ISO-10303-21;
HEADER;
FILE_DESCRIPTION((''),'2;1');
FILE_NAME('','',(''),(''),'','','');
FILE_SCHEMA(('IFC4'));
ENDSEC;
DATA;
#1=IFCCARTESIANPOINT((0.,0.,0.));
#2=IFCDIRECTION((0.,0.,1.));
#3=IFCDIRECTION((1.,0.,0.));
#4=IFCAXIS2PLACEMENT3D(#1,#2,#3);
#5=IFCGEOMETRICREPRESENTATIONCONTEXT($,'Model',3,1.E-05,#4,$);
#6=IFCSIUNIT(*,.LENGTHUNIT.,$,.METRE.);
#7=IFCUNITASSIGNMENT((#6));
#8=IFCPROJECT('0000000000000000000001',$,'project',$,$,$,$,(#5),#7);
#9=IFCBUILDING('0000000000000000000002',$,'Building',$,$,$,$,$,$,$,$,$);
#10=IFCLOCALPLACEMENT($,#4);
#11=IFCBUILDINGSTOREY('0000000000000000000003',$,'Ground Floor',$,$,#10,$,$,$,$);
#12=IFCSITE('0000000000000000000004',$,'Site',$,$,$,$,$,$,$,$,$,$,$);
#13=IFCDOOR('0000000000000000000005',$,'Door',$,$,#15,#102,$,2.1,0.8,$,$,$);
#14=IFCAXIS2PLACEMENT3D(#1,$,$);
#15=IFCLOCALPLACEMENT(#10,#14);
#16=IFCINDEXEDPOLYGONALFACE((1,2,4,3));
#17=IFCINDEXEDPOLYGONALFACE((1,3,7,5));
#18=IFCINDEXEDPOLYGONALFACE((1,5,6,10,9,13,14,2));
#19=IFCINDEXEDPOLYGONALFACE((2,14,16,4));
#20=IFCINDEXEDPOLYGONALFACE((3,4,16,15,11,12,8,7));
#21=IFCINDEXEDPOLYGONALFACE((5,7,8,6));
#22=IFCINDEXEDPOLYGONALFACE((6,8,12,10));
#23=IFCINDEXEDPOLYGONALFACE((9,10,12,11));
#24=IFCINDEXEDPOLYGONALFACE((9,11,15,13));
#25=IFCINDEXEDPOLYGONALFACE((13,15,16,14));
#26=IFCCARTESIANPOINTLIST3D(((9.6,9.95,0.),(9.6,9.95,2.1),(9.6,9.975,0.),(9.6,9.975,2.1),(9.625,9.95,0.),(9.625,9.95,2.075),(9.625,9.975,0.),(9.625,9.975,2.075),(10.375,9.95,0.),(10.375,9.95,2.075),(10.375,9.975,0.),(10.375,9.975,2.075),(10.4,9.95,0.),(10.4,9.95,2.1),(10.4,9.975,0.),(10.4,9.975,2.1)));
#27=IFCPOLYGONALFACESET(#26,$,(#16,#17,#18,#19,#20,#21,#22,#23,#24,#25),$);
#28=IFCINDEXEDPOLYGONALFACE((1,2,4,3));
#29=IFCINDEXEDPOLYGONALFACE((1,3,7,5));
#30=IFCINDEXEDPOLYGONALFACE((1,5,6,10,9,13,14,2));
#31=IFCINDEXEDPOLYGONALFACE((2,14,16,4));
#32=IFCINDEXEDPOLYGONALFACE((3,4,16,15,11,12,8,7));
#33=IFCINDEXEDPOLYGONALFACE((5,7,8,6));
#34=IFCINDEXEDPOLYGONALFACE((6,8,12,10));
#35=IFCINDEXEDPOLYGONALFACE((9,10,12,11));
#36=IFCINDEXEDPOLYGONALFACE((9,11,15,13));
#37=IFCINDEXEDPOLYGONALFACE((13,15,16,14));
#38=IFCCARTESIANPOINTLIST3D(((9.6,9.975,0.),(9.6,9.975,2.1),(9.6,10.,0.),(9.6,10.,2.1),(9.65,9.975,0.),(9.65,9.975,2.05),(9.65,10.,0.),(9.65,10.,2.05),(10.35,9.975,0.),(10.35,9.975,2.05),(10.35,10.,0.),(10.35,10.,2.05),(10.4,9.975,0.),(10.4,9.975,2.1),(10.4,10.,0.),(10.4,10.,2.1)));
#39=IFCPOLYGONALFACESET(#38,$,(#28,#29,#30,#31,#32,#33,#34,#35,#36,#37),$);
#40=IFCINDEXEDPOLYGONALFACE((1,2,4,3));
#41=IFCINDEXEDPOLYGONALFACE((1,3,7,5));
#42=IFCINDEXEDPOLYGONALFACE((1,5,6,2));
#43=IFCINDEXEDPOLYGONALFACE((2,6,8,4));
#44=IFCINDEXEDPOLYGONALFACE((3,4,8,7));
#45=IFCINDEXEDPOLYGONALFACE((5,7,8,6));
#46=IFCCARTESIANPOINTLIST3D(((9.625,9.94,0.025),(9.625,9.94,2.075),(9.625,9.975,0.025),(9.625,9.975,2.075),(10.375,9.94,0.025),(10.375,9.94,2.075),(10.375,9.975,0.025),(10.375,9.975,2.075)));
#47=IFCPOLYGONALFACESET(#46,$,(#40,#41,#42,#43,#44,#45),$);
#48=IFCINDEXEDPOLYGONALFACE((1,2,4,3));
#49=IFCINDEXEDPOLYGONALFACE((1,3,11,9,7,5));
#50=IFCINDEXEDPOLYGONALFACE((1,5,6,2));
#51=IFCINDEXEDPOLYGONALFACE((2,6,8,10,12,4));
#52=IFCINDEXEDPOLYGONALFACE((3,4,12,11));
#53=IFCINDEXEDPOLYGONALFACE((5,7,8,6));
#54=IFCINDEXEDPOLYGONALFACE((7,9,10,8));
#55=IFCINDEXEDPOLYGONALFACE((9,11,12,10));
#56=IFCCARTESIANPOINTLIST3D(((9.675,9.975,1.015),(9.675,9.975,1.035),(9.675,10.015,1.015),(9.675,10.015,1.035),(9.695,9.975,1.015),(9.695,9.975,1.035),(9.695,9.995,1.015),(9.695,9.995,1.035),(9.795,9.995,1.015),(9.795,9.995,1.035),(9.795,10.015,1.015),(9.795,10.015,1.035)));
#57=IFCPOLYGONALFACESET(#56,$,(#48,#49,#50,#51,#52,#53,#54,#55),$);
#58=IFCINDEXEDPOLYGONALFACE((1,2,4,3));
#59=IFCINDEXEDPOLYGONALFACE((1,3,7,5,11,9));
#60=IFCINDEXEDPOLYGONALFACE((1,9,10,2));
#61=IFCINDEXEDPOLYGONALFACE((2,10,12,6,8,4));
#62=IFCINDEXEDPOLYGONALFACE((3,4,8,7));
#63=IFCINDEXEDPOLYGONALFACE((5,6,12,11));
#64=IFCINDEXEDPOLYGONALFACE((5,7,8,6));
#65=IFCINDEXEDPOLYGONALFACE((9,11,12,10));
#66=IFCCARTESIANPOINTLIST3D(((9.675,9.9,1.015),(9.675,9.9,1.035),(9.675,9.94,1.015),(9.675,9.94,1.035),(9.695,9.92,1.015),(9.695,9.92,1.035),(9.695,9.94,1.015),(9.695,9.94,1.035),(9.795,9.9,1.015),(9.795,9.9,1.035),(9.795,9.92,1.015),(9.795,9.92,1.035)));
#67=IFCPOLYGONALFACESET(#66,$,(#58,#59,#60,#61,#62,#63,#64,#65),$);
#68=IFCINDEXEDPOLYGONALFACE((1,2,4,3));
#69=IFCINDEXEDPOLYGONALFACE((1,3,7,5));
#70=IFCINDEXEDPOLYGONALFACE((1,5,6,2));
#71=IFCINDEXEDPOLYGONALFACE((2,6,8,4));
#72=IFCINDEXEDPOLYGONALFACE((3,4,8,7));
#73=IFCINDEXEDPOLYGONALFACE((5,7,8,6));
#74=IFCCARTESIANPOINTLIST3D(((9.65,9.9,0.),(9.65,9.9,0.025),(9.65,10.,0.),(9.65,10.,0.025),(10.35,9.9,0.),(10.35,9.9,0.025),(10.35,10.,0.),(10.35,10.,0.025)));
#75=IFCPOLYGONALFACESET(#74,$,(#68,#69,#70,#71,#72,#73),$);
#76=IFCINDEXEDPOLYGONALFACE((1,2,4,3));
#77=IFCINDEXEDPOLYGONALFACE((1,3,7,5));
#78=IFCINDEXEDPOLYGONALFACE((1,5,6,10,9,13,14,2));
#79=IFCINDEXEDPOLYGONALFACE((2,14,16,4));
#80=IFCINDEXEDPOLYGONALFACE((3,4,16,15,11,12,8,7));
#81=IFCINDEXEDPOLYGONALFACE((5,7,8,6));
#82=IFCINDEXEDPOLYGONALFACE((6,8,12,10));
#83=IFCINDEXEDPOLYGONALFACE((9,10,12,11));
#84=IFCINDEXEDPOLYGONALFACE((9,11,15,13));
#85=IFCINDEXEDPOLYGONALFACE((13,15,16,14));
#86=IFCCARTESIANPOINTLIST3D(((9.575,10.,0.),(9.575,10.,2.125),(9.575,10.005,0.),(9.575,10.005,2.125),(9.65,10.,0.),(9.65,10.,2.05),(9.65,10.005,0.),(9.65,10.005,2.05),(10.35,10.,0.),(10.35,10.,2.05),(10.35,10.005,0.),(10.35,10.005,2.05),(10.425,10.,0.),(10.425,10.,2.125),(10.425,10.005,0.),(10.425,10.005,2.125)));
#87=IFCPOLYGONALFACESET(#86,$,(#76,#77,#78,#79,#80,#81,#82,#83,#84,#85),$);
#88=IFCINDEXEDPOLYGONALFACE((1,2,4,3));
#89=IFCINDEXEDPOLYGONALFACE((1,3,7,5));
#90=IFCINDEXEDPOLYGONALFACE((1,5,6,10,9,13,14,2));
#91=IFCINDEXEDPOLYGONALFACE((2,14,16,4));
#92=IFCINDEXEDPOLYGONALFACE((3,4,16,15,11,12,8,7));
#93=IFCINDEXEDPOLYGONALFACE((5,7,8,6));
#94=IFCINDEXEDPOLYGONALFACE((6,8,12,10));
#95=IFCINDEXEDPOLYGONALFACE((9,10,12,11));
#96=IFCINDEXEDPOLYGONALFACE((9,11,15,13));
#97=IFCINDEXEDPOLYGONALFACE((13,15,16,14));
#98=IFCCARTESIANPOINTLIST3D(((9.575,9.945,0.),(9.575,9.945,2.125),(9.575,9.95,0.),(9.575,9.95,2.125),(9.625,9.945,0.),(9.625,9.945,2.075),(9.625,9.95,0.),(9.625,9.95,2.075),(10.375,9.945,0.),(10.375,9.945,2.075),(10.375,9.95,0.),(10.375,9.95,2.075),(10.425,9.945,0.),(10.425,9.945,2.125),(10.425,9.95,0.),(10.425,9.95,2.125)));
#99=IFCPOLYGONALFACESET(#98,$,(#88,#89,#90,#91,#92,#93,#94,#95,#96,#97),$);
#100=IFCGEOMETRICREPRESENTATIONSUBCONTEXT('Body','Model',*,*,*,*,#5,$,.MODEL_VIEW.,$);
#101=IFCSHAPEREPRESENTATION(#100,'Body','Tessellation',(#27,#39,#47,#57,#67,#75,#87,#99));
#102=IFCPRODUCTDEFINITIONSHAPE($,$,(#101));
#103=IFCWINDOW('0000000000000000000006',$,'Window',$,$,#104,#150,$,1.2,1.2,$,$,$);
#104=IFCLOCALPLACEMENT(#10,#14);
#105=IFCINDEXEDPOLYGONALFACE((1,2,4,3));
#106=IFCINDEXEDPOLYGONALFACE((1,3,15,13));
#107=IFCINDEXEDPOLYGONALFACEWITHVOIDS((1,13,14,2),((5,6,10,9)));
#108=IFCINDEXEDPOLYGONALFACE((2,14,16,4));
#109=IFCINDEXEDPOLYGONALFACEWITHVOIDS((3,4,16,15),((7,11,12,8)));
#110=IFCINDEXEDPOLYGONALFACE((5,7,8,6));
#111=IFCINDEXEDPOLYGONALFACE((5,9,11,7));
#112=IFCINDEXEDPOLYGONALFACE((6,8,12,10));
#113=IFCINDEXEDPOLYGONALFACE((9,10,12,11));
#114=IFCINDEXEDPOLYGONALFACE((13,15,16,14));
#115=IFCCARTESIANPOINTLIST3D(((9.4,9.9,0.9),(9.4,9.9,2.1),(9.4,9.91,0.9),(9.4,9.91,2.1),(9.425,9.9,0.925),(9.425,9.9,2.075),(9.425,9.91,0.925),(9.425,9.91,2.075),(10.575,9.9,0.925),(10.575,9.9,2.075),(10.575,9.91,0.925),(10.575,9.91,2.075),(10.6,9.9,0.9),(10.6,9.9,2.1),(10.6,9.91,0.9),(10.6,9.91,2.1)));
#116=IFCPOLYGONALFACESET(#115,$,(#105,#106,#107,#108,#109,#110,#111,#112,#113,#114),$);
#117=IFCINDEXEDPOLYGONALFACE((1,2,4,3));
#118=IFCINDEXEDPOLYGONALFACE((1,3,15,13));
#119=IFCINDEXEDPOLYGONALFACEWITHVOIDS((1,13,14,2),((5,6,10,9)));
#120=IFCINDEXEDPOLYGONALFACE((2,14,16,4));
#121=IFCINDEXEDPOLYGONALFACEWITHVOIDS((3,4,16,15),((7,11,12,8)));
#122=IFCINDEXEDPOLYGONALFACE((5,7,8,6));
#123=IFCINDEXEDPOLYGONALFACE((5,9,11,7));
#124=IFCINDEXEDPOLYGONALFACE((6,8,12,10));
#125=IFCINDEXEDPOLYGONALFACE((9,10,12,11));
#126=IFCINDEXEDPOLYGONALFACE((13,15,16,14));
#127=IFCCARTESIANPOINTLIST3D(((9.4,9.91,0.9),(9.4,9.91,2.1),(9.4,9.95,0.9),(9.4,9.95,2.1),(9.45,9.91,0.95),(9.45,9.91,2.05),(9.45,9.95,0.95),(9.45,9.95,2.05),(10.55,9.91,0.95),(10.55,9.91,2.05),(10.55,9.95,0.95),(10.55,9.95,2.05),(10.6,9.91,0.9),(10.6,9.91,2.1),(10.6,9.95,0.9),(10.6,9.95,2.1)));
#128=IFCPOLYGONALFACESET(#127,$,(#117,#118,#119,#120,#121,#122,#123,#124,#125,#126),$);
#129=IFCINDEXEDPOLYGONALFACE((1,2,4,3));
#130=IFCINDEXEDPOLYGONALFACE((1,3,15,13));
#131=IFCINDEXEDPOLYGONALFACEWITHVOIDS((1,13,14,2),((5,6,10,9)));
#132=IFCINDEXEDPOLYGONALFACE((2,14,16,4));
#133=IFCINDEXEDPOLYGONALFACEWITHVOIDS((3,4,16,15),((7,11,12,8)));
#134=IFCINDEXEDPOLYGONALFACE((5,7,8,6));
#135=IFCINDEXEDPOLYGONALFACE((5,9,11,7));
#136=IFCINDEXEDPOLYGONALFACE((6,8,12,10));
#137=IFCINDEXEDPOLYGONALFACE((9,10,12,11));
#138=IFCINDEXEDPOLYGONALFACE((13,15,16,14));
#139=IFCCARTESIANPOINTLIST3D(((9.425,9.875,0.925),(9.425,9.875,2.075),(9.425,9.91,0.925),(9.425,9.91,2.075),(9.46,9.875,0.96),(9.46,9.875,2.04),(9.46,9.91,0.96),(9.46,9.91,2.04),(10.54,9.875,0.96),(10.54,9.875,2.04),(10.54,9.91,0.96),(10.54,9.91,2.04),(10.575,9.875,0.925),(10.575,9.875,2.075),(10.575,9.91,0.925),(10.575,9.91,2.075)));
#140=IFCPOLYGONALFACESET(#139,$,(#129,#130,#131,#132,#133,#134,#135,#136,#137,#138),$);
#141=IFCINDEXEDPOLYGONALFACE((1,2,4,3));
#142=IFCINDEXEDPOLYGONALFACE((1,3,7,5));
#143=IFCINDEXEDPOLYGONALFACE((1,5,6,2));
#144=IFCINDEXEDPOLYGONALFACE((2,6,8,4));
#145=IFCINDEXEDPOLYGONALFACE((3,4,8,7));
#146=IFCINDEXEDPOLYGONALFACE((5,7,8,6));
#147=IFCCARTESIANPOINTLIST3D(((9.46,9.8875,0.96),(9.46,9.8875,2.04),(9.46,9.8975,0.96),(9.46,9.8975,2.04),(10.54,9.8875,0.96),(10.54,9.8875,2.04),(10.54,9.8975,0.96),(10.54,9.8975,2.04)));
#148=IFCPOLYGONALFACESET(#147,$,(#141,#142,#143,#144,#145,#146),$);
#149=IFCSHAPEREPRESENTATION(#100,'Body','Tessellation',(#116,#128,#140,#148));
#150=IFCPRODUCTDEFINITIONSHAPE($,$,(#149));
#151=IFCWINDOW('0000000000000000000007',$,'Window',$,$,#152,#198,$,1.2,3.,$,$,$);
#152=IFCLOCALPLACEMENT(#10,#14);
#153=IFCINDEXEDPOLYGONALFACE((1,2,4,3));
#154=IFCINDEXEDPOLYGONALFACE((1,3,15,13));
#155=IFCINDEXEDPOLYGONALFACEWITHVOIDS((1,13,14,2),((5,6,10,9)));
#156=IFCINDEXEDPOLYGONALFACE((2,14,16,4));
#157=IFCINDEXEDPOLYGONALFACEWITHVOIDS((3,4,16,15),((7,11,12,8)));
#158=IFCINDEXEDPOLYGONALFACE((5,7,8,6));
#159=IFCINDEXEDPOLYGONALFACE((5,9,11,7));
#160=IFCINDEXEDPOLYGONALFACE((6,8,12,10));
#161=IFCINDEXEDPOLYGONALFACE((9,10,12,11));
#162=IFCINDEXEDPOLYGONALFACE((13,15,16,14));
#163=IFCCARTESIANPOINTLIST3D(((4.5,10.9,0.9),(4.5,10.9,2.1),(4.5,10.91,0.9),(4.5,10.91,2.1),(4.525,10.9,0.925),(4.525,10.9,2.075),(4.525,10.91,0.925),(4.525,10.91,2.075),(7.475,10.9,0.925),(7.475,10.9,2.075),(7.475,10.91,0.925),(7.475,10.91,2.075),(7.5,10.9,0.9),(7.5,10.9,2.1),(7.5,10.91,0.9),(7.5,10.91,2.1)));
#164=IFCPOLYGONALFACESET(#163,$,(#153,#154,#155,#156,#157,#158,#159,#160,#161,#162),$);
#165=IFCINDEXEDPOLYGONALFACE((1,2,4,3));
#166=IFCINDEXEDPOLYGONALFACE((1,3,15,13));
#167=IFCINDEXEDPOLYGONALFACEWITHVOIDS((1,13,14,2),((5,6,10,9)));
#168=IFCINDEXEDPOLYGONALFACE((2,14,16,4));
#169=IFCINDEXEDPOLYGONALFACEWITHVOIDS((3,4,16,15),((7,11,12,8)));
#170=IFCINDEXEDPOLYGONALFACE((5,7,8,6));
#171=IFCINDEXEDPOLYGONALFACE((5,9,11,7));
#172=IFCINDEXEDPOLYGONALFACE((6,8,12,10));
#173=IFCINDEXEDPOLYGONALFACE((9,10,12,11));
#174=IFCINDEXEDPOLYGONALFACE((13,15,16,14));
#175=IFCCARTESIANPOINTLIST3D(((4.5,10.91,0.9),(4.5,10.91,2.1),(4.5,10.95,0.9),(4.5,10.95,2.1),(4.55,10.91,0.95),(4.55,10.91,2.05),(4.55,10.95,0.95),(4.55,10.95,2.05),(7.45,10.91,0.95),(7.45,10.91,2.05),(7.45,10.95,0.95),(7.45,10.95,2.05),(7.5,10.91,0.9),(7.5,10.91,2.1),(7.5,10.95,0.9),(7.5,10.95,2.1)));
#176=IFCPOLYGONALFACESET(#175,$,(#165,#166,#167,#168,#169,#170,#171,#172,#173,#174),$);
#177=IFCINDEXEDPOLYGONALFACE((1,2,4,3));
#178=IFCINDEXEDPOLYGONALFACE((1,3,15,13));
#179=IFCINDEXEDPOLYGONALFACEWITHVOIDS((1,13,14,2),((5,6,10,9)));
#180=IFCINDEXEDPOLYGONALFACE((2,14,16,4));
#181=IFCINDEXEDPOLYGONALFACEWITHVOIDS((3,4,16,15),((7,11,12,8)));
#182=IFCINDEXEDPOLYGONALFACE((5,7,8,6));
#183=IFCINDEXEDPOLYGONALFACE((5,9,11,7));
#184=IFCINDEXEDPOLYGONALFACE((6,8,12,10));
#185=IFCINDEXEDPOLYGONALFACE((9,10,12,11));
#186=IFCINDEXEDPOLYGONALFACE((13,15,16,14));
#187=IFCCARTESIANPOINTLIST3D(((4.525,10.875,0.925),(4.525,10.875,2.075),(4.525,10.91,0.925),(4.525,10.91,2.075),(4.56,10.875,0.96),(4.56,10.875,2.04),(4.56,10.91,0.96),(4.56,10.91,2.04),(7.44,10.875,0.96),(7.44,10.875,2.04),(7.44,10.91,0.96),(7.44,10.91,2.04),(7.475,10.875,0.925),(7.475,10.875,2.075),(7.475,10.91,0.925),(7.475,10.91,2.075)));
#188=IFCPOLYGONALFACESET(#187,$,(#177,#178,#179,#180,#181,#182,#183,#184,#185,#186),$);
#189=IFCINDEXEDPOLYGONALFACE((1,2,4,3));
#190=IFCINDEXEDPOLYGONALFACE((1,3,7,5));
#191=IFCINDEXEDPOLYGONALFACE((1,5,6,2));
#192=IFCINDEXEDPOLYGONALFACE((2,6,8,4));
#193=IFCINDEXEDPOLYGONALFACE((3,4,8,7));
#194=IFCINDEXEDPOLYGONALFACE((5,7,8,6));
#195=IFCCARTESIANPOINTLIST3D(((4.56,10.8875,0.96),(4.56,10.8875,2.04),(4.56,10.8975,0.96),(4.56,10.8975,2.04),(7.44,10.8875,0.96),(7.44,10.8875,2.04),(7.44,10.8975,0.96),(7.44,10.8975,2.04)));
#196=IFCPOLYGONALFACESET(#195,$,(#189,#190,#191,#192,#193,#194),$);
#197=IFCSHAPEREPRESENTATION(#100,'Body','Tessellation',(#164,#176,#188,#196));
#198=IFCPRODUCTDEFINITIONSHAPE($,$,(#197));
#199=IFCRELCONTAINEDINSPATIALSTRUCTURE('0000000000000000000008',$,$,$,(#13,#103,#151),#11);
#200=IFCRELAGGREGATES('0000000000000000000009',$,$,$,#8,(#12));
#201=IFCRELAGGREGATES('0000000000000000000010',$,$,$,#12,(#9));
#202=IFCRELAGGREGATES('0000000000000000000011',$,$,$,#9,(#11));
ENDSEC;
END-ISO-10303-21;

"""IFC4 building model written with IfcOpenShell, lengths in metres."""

from ifc_helpers import new_model, si_unit, frame, origin_with_axes, place, context, subcontext, project, spatial, line, indexed_curve, outline, extrude, element, save


model = new_model("IFC4")

# Units and contexts
model_context = context("Model", 3, precision=1e-05, world=origin_with_axes())
body_context = subcontext(model_context, "Body", "Model", "MODEL_VIEW")
ifc_project = project(units=[si_unit("LENGTHUNIT", "METRE")], contexts=[model_context])

# Site, building, storey
site = spatial("IfcSite", under=ifc_project, Name="Site")
building = spatial("IfcBuilding", under=site, Name="Building")
storey_placement = place(None, origin_with_axes())
storey = spatial("IfcBuildingStorey", under=building, at=storey_placement, Name="Ground Floor")

# Door
door_1_placement = place(storey_placement, frame((10.4, 10.0, 0.0), z_axis=(0.0, 0.0, 1.0), x_axis=(-1.0, 0.0, 0.0)))
element("IfcDoor", 1, at=door_1_placement, inside=storey, Name="Door", OverallHeight=2.1, OverallWidth=0.8, context=body_context, shape_type="SweptSolid", body=[
    extrude(outline(indexed_curve([(0.0, 0.0), (0.0, 2.1), (0.8, 2.1), (0.8, 0.0), (0.775, 0.0), (0.775, 2.075), (0.025, 2.075), (0.025, 0.0)], segments=[line(1, 2, 3, 4, 5, 6, 7, 8, 1)])), frame((0.0, 0.025, 0.0), z_axis=(0.0, -1.0, 0.0), x_axis=(1.0, 0.0, 0.0)), (0.0, 0.0, -1.0), 0.025),
    extrude(outline(indexed_curve([(0.0, 0.0), (0.0, 2.1), (0.8, 2.1), (0.8, 0.0), (0.75, 0.0), (0.75, 2.05), (0.05, 2.05), (0.05, 0.0)], segments=[line(1, 2, 3, 4, 5, 6, 7, 8, 1)])), frame((0.0, 0.0, 0.0), z_axis=(0.0, -1.0, 0.0), x_axis=(1.0, 0.0, 0.0)), (0.0, 0.0, -1.0), 0.025),
    extrude(outline(indexed_curve([(0.0, 0.0), (0.75, 0.0), (0.75, 0.035), (0.0, 0.035)], segments=[line(1, 2, 3, 4, 1)])), frame((0.025, 0.025, 0.025), z_axis=(0.0, 0.0, 1.0), x_axis=(1.0, 0.0, 0.0)), (0.0, 0.0, 1.0), 2.05),
    extrude(outline(indexed_curve([(0.0, 0.0), (0.0, -0.04), (-0.12, -0.04), (-0.12, -0.02), (-0.02, -0.02), (-0.02, 0.0)], segments=[line(1, 2, 3, 4, 5, 6, 1)])), frame((0.725, 0.025, 1.015), z_axis=(0.0, 0.0, 1.0), x_axis=(1.0, 0.0, 0.0)), (0.0, 0.0, 1.0), 0.02),
    extrude(outline(indexed_curve([(0.0, 0.0), (0.0, 0.04), (-0.12, 0.04), (-0.12, 0.02), (-0.02, 0.02), (-0.02, 0.0)], segments=[line(1, 2, 3, 4, 5, 6, 1)])), frame((0.725, 0.06, 1.015), z_axis=(0.0, 0.0, 1.0), x_axis=(1.0, 0.0, 0.0)), (0.0, 0.0, 1.0), 0.02),
    extrude(outline(indexed_curve([(0.0, 0.0), (0.7, 0.0), (0.7, 0.1), (0.0, 0.1)], segments=[line(1, 2, 3, 4, 1)])), frame((0.05, 0.0, 0.0), z_axis=(0.0, 0.0, 1.0), x_axis=(1.0, 0.0, 0.0)), (0.0, 0.0, 1.0), 0.025),
    extrude(outline(indexed_curve([(0.0, 0.0), (0.0, 2.125), (0.85, 2.125), (0.85, 0.0), (0.775, 0.0), (0.775, 2.05), (0.075, 2.05), (0.075, 0.0)], segments=[line(1, 2, 3, 4, 5, 6, 7, 8, 1)])), frame((-0.025, -0.005, 0.0), z_axis=(0.0, -1.0, 0.0), x_axis=(1.0, 0.0, 0.0)), (0.0, 0.0, -1.0), 0.005),
    extrude(outline(indexed_curve([(0.0, 0.0), (0.0, 2.125), (0.85, 2.125), (0.85, 0.0), (0.8, 0.0), (0.8, 2.075), (0.05, 2.075), (0.05, 0.0)], segments=[line(1, 2, 3, 4, 5, 6, 7, 8, 1)])), frame((-0.025, 0.05, 0.0), z_axis=(0.0, -1.0, 0.0), x_axis=(1.0, 0.0, 0.0)), (0.0, 0.0, -1.0), 0.005),
])

# Windows
window_1_placement = place(storey_placement, frame((10.6, 10.0, 0.9), z_axis=(0.0, 0.0, 1.0), x_axis=(-1.0, 0.0, 0.0)))
element("IfcWindow", 2, at=window_1_placement, inside=storey, Name="Window", OverallHeight=1.2, OverallWidth=1.2, context=body_context, shape_type="SweptSolid", body=[
    extrude(outline(indexed_curve([(0.0, 0.0), (1.2, 0.0), (1.2, 1.2), (0.0, 1.2)], segments=[line(1, 2, 3, 4, 1)]), holes=[indexed_curve([(0.025, 0.025), (1.175, 0.025), (1.175, 1.175), (0.025, 1.175)], segments=[line(1, 2, 3, 4, 1)])]), frame((0.0, 0.09, 0.0), z_axis=(0.0, -1.0, 0.0), x_axis=(1.0, 0.0, 0.0)), (0.0, 0.0, -1.0), 0.01),
    extrude(outline(indexed_curve([(0.0, 0.0), (1.2, 0.0), (1.2, 1.2), (0.0, 1.2)], segments=[line(1, 2, 3, 4, 1)]), holes=[indexed_curve([(0.05, 0.05), (1.15, 0.05), (1.15, 1.15), (0.05, 1.15)], segments=[line(1, 2, 3, 4, 1)])]), frame((0.0, 0.05, 0.0), z_axis=(0.0, -1.0, 0.0), x_axis=(1.0, 0.0, 0.0)), (0.0, 0.0, -1.0), 0.04),
    extrude(outline(indexed_curve([(0.0, 0.0), (1.15, 0.0), (1.15, 1.15), (0.0, 1.15)], segments=[line(1, 2, 3, 4, 1)]), holes=[indexed_curve([(0.035, 0.035), (1.115, 0.035), (1.115, 1.115), (0.035, 1.115)], segments=[line(1, 2, 3, 4, 1)])]), frame((0.025, 0.09, 0.025), z_axis=(0.0, -1.0, 0.0), x_axis=(1.0, 0.0, 0.0)), (0.0, 0.0, -1.0), 0.035),
    extrude(outline(indexed_curve([(0.035, 0.035), (1.115, 0.035), (1.115, 1.115), (0.035, 1.115)], segments=[line(1, 2, 3, 4, 1)])), frame((0.025, 0.1025, 0.025), z_axis=(0.0, -1.0, 0.0), x_axis=(1.0, 0.0, 0.0)), (0.0, 0.0, -1.0), 0.01),
])
window_2_placement = place(storey_placement, frame((7.5, 11.0, 0.9), z_axis=(0.0, 0.0, 1.0), x_axis=(-1.0, 0.0, 0.0)))
element("IfcWindow", 3, at=window_2_placement, inside=storey, Name="Window", OverallHeight=1.2, OverallWidth=3.0, context=body_context, shape_type="SweptSolid", body=[
    extrude(outline(indexed_curve([(0.0, 0.0), (3.0, 0.0), (3.0, 1.2), (0.0, 1.2)], segments=[line(1, 2, 3, 4, 1)]), holes=[indexed_curve([(0.025, 0.025), (2.975, 0.025), (2.975, 1.175), (0.025, 1.175)], segments=[line(1, 2, 3, 4, 1)])]), frame((0.0, 0.09, 0.0), z_axis=(0.0, -1.0, 0.0), x_axis=(1.0, 0.0, 0.0)), (0.0, 0.0, -1.0), 0.01),
    extrude(outline(indexed_curve([(0.0, 0.0), (3.0, 0.0), (3.0, 1.2), (0.0, 1.2)], segments=[line(1, 2, 3, 4, 1)]), holes=[indexed_curve([(0.05, 0.05), (2.95, 0.05), (2.95, 1.15), (0.05, 1.15)], segments=[line(1, 2, 3, 4, 1)])]), frame((0.0, 0.05, 0.0), z_axis=(0.0, -1.0, 0.0), x_axis=(1.0, 0.0, 0.0)), (0.0, 0.0, -1.0), 0.04),
    extrude(outline(indexed_curve([(0.0, 0.0), (2.95, 0.0), (2.95, 1.15), (0.0, 1.15)], segments=[line(1, 2, 3, 4, 1)]), holes=[indexed_curve([(0.035, 0.035), (2.915, 0.035), (2.915, 1.115), (0.035, 1.115)], segments=[line(1, 2, 3, 4, 1)])]), frame((0.025, 0.09, 0.025), z_axis=(0.0, -1.0, 0.0), x_axis=(1.0, 0.0, 0.0)), (0.0, 0.0, -1.0), 0.035),
    extrude(outline(indexed_curve([(0.035, 0.035), (2.915, 0.035), (2.915, 1.115), (0.035, 1.115)], segments=[line(1, 2, 3, 4, 1)])), frame((0.025, 0.1025, 0.025), z_axis=(0.0, -1.0, 0.0), x_axis=(1.0, 0.0, 0.0)), (0.0, 0.0, -1.0), 0.01),
])

save(model, "model.ifc")
